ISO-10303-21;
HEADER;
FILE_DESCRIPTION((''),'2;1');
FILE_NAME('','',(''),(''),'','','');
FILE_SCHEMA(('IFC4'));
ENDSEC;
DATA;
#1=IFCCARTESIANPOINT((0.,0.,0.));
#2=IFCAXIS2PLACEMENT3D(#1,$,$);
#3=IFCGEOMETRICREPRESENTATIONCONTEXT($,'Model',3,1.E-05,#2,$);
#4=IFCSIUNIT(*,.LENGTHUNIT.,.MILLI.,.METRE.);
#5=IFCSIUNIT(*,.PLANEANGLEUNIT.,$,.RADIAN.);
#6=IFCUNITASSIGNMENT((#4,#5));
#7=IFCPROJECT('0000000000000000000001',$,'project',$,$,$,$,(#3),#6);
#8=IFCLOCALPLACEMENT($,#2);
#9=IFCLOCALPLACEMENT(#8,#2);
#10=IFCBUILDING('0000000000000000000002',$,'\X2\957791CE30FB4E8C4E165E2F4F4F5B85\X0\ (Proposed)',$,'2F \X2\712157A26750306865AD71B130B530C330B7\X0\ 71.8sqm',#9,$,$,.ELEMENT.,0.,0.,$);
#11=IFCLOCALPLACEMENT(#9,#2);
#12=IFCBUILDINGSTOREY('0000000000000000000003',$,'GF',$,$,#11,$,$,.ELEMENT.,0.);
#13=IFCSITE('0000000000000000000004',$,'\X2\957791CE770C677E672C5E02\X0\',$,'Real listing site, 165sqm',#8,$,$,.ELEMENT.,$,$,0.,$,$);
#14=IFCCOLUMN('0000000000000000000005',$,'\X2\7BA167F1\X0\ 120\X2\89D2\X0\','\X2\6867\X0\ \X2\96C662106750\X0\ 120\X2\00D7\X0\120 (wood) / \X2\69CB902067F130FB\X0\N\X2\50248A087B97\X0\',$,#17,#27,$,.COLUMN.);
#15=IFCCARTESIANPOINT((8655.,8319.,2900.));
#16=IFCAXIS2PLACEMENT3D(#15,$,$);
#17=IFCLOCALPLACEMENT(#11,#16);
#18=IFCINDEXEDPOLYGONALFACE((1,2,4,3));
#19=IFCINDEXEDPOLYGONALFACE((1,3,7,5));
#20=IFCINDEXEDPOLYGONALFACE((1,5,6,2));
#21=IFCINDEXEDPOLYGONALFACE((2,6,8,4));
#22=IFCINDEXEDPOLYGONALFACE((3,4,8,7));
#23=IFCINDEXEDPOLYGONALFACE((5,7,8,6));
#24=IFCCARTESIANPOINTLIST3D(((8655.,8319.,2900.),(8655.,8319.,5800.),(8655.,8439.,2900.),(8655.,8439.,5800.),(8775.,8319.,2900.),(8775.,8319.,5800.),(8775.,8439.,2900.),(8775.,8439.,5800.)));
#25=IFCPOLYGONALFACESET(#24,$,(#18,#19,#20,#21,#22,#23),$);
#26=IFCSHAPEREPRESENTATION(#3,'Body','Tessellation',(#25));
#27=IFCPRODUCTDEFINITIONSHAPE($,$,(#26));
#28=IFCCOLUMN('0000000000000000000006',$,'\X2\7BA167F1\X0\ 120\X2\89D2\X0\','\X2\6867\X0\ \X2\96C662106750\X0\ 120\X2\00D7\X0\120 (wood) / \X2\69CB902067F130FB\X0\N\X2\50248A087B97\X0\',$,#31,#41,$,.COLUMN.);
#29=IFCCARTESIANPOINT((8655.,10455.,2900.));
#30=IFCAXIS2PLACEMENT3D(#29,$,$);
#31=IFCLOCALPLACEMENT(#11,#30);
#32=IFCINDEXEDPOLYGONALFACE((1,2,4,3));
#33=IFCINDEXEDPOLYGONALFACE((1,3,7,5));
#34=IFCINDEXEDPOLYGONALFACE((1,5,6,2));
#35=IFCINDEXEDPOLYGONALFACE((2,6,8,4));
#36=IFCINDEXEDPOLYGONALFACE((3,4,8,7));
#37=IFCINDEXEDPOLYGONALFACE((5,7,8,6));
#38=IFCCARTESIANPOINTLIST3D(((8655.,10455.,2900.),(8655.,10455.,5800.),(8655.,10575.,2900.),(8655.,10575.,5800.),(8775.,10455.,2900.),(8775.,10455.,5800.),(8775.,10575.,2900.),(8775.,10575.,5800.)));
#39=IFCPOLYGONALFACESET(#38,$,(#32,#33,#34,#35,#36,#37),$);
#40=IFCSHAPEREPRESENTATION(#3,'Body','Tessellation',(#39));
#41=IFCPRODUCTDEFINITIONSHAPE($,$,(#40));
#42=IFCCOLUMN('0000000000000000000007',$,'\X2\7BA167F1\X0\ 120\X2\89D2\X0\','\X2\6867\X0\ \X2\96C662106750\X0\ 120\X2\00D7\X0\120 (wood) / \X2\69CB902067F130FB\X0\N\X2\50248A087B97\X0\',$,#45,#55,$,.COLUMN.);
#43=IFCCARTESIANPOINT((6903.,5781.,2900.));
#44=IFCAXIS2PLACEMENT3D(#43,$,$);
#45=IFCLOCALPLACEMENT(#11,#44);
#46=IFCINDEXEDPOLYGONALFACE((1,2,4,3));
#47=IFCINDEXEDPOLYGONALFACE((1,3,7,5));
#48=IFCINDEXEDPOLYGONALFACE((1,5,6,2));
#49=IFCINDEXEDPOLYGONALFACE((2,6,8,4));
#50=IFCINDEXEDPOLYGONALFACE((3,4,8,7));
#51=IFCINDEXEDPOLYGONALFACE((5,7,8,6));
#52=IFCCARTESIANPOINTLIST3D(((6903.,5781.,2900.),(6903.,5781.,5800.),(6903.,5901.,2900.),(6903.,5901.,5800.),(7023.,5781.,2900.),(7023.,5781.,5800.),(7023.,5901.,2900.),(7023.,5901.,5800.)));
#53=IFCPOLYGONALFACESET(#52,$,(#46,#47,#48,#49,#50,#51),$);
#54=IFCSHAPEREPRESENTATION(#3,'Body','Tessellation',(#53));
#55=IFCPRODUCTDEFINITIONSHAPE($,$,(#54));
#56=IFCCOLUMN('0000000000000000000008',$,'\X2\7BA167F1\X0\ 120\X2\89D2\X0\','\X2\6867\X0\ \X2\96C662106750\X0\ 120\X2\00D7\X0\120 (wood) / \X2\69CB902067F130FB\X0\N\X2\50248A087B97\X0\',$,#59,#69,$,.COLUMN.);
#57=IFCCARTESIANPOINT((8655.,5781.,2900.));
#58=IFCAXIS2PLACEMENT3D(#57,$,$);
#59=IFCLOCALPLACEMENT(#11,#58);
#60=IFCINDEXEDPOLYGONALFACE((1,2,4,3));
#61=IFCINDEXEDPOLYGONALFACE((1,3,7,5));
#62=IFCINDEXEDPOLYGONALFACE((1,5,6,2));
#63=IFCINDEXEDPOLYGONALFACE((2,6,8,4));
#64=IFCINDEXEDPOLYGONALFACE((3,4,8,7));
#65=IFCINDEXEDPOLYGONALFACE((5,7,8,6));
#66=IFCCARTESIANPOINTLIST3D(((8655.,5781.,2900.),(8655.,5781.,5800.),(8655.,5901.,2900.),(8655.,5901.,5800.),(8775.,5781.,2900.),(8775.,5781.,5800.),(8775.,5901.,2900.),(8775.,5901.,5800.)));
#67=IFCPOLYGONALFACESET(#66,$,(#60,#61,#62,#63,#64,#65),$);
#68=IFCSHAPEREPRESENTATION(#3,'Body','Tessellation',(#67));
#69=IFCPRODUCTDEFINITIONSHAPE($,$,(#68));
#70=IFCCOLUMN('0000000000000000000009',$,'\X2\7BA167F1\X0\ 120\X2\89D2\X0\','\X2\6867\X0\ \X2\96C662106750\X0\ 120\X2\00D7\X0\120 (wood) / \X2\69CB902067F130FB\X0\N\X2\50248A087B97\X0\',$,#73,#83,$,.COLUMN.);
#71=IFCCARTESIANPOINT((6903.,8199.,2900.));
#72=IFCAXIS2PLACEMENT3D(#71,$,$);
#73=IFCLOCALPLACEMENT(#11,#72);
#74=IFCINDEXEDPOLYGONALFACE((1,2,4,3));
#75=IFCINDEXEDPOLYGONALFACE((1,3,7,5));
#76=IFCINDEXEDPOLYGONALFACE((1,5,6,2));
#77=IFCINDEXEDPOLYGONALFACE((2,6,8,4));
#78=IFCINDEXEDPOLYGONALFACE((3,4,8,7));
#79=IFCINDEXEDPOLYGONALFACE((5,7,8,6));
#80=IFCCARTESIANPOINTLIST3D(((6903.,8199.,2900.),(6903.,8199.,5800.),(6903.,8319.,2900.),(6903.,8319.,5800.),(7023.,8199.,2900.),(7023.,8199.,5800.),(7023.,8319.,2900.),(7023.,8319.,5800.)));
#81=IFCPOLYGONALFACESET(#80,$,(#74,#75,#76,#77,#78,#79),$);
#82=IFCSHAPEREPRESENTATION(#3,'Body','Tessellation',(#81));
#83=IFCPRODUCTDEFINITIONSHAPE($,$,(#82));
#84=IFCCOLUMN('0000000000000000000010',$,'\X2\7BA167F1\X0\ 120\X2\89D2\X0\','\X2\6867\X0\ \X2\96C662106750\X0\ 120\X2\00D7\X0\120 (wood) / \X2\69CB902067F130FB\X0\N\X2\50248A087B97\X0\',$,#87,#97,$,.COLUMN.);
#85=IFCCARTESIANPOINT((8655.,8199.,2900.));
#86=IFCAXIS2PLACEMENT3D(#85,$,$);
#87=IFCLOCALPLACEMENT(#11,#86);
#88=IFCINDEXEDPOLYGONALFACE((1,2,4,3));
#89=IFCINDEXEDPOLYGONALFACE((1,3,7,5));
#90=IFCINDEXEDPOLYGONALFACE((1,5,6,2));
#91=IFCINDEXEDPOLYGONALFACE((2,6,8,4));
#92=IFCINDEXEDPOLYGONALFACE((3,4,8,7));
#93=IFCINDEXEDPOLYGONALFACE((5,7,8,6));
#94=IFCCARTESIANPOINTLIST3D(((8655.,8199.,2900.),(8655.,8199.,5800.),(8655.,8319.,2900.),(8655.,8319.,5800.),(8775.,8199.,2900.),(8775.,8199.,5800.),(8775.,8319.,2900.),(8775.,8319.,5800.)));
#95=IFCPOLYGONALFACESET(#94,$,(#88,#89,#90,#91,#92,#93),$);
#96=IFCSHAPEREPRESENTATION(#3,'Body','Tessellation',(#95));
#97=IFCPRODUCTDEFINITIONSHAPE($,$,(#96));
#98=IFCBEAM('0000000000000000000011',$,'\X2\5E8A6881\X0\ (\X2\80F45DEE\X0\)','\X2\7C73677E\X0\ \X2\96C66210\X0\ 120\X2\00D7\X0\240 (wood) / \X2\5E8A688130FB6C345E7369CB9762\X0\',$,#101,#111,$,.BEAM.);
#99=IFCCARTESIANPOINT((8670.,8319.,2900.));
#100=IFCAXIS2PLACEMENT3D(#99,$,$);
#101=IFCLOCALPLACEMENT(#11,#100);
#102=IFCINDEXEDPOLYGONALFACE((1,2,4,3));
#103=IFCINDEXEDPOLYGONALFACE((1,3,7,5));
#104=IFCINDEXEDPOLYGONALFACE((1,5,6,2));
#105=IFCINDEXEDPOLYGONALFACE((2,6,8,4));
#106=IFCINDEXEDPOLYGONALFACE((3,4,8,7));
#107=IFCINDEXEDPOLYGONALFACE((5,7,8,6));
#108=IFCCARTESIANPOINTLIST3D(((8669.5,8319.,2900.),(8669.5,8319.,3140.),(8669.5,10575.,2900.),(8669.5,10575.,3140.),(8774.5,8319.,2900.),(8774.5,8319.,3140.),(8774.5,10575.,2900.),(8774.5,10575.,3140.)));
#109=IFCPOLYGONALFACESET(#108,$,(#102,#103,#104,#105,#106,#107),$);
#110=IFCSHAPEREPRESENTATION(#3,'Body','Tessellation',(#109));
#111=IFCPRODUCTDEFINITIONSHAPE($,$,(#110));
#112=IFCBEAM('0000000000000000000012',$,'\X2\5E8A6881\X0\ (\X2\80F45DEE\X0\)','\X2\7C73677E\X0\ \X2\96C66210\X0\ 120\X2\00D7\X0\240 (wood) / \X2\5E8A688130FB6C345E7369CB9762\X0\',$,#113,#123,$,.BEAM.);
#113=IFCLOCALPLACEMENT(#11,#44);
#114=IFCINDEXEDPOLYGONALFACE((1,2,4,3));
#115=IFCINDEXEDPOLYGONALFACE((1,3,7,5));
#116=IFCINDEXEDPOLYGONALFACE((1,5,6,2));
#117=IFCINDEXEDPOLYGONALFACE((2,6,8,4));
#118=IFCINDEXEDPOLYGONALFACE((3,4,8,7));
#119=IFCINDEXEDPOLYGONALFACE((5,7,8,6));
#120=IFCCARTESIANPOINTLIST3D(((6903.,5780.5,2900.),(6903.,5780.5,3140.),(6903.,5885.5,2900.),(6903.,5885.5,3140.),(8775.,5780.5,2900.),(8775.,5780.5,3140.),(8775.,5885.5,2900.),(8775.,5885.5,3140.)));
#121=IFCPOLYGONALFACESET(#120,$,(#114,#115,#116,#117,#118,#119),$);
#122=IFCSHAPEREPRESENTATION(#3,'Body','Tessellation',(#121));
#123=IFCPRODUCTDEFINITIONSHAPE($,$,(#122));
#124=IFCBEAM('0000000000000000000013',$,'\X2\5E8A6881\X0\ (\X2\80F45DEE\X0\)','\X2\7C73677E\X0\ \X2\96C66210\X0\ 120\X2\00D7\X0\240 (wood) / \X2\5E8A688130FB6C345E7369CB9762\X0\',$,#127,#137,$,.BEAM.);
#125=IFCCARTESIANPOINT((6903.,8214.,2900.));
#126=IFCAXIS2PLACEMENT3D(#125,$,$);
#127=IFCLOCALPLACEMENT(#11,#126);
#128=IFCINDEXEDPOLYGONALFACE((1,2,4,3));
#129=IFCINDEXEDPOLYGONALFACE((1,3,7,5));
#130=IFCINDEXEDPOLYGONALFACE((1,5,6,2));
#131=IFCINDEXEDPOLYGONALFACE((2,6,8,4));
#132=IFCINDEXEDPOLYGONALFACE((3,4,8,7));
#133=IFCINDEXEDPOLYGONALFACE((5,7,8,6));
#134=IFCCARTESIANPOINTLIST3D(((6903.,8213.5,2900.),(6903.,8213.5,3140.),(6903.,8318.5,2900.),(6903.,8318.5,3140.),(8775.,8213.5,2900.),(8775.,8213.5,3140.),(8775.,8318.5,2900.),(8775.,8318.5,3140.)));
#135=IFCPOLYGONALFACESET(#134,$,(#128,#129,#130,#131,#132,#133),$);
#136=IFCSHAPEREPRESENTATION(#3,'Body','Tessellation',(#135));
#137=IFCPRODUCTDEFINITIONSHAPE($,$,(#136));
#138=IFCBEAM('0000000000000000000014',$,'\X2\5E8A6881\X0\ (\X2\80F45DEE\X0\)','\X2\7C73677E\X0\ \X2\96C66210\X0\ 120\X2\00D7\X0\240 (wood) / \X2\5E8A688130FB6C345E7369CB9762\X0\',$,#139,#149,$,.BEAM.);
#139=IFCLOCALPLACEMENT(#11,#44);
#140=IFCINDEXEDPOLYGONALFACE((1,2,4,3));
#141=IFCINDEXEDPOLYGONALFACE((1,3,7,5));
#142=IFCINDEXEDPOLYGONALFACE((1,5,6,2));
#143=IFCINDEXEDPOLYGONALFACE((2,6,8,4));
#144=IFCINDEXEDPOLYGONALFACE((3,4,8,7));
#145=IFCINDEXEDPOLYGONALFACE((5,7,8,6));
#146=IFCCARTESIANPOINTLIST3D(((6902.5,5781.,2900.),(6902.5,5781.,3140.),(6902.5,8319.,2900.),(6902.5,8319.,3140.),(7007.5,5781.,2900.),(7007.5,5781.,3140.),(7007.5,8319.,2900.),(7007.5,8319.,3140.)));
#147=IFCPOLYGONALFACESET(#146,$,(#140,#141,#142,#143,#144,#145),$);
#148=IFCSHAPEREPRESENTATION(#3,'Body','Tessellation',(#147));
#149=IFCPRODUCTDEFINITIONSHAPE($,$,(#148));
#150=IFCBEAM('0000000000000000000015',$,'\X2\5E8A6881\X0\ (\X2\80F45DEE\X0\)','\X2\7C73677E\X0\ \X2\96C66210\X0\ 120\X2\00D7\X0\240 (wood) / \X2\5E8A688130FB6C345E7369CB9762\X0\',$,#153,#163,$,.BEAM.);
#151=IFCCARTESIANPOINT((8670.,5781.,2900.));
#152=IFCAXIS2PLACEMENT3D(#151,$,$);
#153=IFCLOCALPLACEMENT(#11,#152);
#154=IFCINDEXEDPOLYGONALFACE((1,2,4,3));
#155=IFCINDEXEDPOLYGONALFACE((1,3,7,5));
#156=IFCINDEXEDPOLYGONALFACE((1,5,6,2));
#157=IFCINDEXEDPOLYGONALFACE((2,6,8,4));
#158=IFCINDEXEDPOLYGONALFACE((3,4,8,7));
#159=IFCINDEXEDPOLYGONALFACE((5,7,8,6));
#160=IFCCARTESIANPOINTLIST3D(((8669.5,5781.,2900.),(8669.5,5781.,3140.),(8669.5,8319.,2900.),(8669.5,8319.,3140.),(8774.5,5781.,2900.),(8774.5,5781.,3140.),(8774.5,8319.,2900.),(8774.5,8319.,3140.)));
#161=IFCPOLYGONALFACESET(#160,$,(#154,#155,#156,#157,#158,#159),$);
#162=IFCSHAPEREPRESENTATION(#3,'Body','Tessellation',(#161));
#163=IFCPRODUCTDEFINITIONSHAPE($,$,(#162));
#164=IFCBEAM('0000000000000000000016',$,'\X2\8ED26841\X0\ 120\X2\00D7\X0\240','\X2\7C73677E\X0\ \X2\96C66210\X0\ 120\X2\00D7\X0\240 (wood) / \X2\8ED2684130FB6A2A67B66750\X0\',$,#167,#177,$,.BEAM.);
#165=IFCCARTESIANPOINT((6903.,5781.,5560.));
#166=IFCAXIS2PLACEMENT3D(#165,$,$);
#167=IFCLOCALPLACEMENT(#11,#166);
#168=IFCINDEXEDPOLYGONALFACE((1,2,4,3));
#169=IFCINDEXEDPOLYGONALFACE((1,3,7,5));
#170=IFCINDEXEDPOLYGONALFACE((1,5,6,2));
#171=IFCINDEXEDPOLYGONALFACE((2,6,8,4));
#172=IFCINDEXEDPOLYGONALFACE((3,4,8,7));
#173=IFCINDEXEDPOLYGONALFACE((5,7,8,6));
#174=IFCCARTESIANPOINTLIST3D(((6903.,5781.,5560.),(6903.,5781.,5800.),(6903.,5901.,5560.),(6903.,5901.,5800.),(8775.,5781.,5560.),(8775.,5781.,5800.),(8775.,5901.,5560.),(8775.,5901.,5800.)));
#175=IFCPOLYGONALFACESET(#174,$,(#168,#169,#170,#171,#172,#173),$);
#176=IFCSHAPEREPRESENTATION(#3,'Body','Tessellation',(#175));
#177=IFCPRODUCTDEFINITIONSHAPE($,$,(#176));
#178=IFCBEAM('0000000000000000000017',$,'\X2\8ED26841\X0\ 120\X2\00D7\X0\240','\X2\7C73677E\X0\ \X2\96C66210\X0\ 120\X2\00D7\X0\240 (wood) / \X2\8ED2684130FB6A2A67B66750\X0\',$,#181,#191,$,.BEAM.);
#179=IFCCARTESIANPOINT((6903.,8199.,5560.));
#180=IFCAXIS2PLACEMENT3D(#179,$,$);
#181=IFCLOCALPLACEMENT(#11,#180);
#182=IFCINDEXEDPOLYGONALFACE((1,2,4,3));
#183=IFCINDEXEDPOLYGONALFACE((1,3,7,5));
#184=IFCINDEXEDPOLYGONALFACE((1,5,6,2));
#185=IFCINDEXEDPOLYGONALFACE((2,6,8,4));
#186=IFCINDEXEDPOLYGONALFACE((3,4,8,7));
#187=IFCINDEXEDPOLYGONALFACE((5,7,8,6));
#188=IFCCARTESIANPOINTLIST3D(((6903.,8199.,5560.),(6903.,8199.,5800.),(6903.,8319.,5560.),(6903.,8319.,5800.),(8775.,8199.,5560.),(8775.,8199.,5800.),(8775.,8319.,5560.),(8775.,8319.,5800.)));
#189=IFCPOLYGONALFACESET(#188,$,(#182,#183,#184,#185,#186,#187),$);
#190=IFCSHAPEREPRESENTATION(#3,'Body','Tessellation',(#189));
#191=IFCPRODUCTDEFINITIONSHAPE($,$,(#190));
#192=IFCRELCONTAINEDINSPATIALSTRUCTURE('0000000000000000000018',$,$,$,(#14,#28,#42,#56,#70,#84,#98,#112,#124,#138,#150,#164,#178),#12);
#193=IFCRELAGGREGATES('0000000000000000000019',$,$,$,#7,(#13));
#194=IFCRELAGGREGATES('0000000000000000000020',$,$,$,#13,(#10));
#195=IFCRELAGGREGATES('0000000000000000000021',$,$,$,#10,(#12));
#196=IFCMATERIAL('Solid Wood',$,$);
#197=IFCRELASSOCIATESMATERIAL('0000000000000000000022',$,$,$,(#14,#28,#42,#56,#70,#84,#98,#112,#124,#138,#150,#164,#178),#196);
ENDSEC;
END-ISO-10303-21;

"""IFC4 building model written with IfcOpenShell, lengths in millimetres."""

from ifc_helpers import new_model, si_unit, frame, frame_2d, origin, place, context, project, spatial, rectangle, extrude, material, element, save


model = new_model("IFC4")

# Units and contexts
model_context = context("Model", 3, precision=1e-05, world=origin())
ifc_project = project(units=[si_unit("LENGTHUNIT", "METRE", prefix="MILLI"), si_unit("PLANEANGLEUNIT", "RADIAN")], contexts=[model_context])

# Site, building, storey
site_placement = place(None, origin())
site = spatial("IfcSite", under=ifc_project, at=site_placement, Name="長野県松本市", ObjectType="Real listing site, 165sqm", CompositionType="ELEMENT", RefElevation=0.0)
building_placement = place(site_placement, origin())
building = spatial("IfcBuilding", under=site, at=building_placement, Name="長野・二世帯住宅 (Proposed)", ObjectType="2F 無垢材と断熱サッシ 71.8sqm", CompositionType="ELEMENT", ElevationOfRefHeight=0.0, ElevationOfTerrain=0.0)
storey_placement = place(building_placement, origin())
storey = spatial("IfcBuildingStorey", under=building, at=storey_placement, Name="GF", CompositionType="ELEMENT", Elevation=0.0)

# Columns
ifc_material_1 = material(Name="Solid Wood")
column_1_placement = place(storey_placement, frame((8655.0, 8319.0, 2900.0)))
element("IfcColumn", 1, at=column_1_placement, inside=storey, material=ifc_material_1, Name="管柱 120角", Description="桧 集成材 120×120 (wood) / 構造柱・N値計算", PredefinedType="COLUMN", context=model_context, shape_type="SweptSolid", body=[
    extrude(rectangle(XDim=120.0, YDim=120.0, at=frame_2d((60.0, 60.0))), frame((8655.0, 8319.0, 2900.0)), (0.0, 0.0, 1.0), 2900.0),
])
column_2_placement = place(storey_placement, frame((8655.0, 10455.0, 2900.0)))
element("IfcColumn", 2, at=column_2_placement, inside=storey, material=ifc_material_1, Name="管柱 120角", Description="桧 集成材 120×120 (wood) / 構造柱・N値計算", PredefinedType="COLUMN", context=model_context, shape_type="SweptSolid", body=[
    extrude(rectangle(XDim=120.0, YDim=120.0, at=frame_2d((60.0, 60.0))), frame((8655.0, 10455.0, 2900.0)), (0.0, 0.0, 1.0), 2900.0),
])
column_3_placement = place(storey_placement, frame((6903.0, 5781.0, 2900.0)))
element("IfcColumn", 3, at=column_3_placement, inside=storey, material=ifc_material_1, Name="管柱 120角", Description="桧 集成材 120×120 (wood) / 構造柱・N値計算", PredefinedType="COLUMN", context=model_context, shape_type="SweptSolid", body=[
    extrude(rectangle(XDim=120.0, YDim=120.0, at=frame_2d((60.0, 60.0))), frame((6903.0, 5781.0, 2900.0)), (0.0, 0.0, 1.0), 2900.0),
])
column_4_placement = place(storey_placement, frame((8655.0, 5781.0, 2900.0)))
element("IfcColumn", 4, at=column_4_placement, inside=storey, material=ifc_material_1, Name="管柱 120角", Description="桧 集成材 120×120 (wood) / 構造柱・N値計算", PredefinedType="COLUMN", context=model_context, shape_type="SweptSolid", body=[
    extrude(rectangle(XDim=120.0, YDim=120.0, at=frame_2d((60.0, 60.0))), frame((8655.0, 5781.0, 2900.0)), (0.0, 0.0, 1.0), 2900.0),
])
column_5_placement = place(storey_placement, frame((6903.0, 8199.0, 2900.0)))
element("IfcColumn", 5, at=column_5_placement, inside=storey, material=ifc_material_1, Name="管柱 120角", Description="桧 集成材 120×120 (wood) / 構造柱・N値計算", PredefinedType="COLUMN", context=model_context, shape_type="SweptSolid", body=[
    extrude(rectangle(XDim=120.0, YDim=120.0, at=frame_2d((60.0, 60.0))), frame((6903.0, 8199.0, 2900.0)), (0.0, 0.0, 1.0), 2900.0),
])
column_6_placement = place(storey_placement, frame((8655.0, 8199.0, 2900.0)))
element("IfcColumn", 6, at=column_6_placement, inside=storey, material=ifc_material_1, Name="管柱 120角", Description="桧 集成材 120×120 (wood) / 構造柱・N値計算", PredefinedType="COLUMN", context=model_context, shape_type="SweptSolid", body=[
    extrude(rectangle(XDim=120.0, YDim=120.0, at=frame_2d((60.0, 60.0))), frame((8655.0, 8199.0, 2900.0)), (0.0, 0.0, 1.0), 2900.0),
])

# Beams
beam_1_placement = place(storey_placement, frame((8670.0, 8319.0, 2900.0)))
element("IfcBeam", 7, at=beam_1_placement, inside=storey, material=ifc_material_1, Name="床梁 (胴差)", Description="米松 集成 120×240 (wood) / 床梁・水平構面", PredefinedType="BEAM", context=model_context, shape_type="SweptSolid", body=[
    extrude(rectangle(XDim=105.0, YDim=2256.0, at=frame_2d((52.0, 1128.0))), frame((8670.0, 8319.0, 2900.0)), (0.0, 0.0, 1.0), 240.0),
])
beam_2_placement = place(storey_placement, frame((6903.0, 5781.0, 2900.0)))
element("IfcBeam", 8, at=beam_2_placement, inside=storey, material=ifc_material_1, Name="床梁 (胴差)", Description="米松 集成 120×240 (wood) / 床梁・水平構面", PredefinedType="BEAM", context=model_context, shape_type="SweptSolid", body=[
    extrude(rectangle(XDim=1872.0, YDim=105.0, at=frame_2d((936.0, 52.0))), frame((6903.0, 5781.0, 2900.0)), (0.0, 0.0, 1.0), 240.0),
])
beam_3_placement = place(storey_placement, frame((6903.0, 8214.0, 2900.0)))
element("IfcBeam", 9, at=beam_3_placement, inside=storey, material=ifc_material_1, Name="床梁 (胴差)", Description="米松 集成 120×240 (wood) / 床梁・水平構面", PredefinedType="BEAM", context=model_context, shape_type="SweptSolid", body=[
    extrude(rectangle(XDim=1872.0, YDim=105.0, at=frame_2d((936.0, 52.0))), frame((6903.0, 8214.0, 2900.0)), (0.0, 0.0, 1.0), 240.0),
])
beam_4_placement = place(storey_placement, frame((6903.0, 5781.0, 2900.0)))
element("IfcBeam", 10, at=beam_4_placement, inside=storey, material=ifc_material_1, Name="床梁 (胴差)", Description="米松 集成 120×240 (wood) / 床梁・水平構面", PredefinedType="BEAM", context=model_context, shape_type="SweptSolid", body=[
    extrude(rectangle(XDim=105.0, YDim=2538.0, at=frame_2d((52.0, 1269.0))), frame((6903.0, 5781.0, 2900.0)), (0.0, 0.0, 1.0), 240.0),
])
beam_5_placement = place(storey_placement, frame((8670.0, 5781.0, 2900.0)))
element("IfcBeam", 11, at=beam_5_placement, inside=storey, material=ifc_material_1, Name="床梁 (胴差)", Description="米松 集成 120×240 (wood) / 床梁・水平構面", PredefinedType="BEAM", context=model_context, shape_type="SweptSolid", body=[
    extrude(rectangle(XDim=105.0, YDim=2538.0, at=frame_2d((52.0, 1269.0))), frame((8670.0, 5781.0, 2900.0)), (0.0, 0.0, 1.0), 240.0),
])
beam_6_placement = place(storey_placement, frame((6903.0, 5781.0, 5560.0)))
element("IfcBeam", 12, at=beam_6_placement, inside=storey, material=ifc_material_1, Name="軒桁 120×240", Description="米松 集成 120×240 (wood) / 軒桁・横架材", PredefinedType="BEAM", context=model_context, shape_type="SweptSolid", body=[
    extrude(rectangle(XDim=1872.0, YDim=120.0, at=frame_2d((936.0, 60.0))), frame((6903.0, 5781.0, 5560.0)), (0.0, 0.0, 1.0), 240.0),
])
beam_7_placement = place(storey_placement, frame((6903.0, 8199.0, 5560.0)))
element("IfcBeam", 13, at=beam_7_placement, inside=storey, material=ifc_material_1, Name="軒桁 120×240", Description="米松 集成 120×240 (wood) / 軒桁・横架材", PredefinedType="BEAM", context=model_context, shape_type="SweptSolid", body=[
    extrude(rectangle(XDim=1872.0, YDim=120.0, at=frame_2d((936.0, 60.0))), frame((6903.0, 8199.0, 5560.0)), (0.0, 0.0, 1.0), 240.0),
])

save(model, "model.ifc")
